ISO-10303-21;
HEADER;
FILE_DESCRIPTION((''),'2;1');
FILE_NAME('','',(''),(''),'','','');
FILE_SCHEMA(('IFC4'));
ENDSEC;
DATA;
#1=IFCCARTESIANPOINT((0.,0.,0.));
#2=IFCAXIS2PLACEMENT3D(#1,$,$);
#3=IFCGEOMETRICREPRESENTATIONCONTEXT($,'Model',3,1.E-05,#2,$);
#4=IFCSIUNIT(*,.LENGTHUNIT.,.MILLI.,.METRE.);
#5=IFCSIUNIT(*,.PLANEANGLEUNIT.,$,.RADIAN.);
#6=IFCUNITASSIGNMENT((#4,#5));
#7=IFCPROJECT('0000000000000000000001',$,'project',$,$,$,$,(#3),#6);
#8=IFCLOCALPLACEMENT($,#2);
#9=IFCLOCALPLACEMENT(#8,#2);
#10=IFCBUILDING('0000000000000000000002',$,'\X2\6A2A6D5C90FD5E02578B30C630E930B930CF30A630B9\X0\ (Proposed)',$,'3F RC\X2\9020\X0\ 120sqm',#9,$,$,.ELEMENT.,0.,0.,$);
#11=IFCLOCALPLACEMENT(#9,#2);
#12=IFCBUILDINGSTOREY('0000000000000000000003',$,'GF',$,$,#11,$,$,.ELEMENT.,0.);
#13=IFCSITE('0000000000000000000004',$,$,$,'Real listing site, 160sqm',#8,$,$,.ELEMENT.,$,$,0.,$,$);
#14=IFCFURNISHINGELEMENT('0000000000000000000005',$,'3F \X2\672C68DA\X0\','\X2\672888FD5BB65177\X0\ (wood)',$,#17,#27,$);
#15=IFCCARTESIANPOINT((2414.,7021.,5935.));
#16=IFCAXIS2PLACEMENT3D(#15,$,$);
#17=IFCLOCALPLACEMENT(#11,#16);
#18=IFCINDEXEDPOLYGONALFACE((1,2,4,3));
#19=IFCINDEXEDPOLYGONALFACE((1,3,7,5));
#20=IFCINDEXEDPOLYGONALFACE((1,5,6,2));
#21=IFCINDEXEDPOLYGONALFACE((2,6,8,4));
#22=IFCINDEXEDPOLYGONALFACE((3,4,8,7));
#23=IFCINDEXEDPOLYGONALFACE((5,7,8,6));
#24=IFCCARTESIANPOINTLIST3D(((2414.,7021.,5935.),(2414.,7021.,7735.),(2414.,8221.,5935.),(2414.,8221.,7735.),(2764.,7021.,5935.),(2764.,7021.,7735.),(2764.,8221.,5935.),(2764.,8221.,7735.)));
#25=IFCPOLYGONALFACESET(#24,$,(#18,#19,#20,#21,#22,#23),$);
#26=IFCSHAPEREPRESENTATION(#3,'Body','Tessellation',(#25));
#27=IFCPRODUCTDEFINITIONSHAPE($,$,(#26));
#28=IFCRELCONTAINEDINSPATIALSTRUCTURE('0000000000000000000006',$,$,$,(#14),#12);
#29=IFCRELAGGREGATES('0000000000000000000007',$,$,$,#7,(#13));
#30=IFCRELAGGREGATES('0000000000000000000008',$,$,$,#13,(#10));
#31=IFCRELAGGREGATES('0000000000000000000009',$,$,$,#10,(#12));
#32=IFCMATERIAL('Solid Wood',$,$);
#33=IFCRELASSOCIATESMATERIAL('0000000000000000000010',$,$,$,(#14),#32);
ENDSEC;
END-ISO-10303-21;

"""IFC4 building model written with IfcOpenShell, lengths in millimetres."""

from ifc_helpers import new_model, si_unit, frame, frame_2d, origin, place, context, project, spatial, rectangle, extrude, material, element, save


model = new_model("IFC4")

# Units and contexts
model_context = context("Model", 3, precision=1e-05, world=origin())
ifc_project = project(units=[si_unit("LENGTHUNIT", "METRE", prefix="MILLI"), si_unit("PLANEANGLEUNIT", "RADIAN")], contexts=[model_context])

# Site, building, storey
site_placement = place(None, origin())
site = spatial("IfcSite", under=ifc_project, at=site_placement, ObjectType="Real listing site, 160sqm", CompositionType="ELEMENT", RefElevation=0.0)
building_placement = place(site_placement, origin())
building = spatial("IfcBuilding", under=site, at=building_placement, Name="横浜都市型テラスハウス (Proposed)", ObjectType="3F RC造 120sqm", CompositionType="ELEMENT", ElevationOfRefHeight=0.0, ElevationOfTerrain=0.0)
storey_placement = place(building_placement, origin())
storey = spatial("IfcBuildingStorey", under=building, at=storey_placement, Name="GF", CompositionType="ELEMENT", Elevation=0.0)

# Shared definitions
ifc_material_1 = material(Name="Solid Wood")

# Furnishing element
furnishing_1_placement = place(storey_placement, frame((2414.0, 7021.0, 5935.0)))
element("IfcFurnishingElement", 1, at=furnishing_1_placement, inside=storey, material=ifc_material_1, Name="3F 本棚", Description="木製家具 (wood)", context=model_context, shape_type="SweptSolid", body=[
    extrude(rectangle(XDim=350.0, YDim=1200.0, at=frame_2d((175.0, 600.0))), frame((2414.0, 7021.0, 5935.0)), (0.0, 0.0, 1.0), 1800.0),
])

save(model, "model.ifc")
